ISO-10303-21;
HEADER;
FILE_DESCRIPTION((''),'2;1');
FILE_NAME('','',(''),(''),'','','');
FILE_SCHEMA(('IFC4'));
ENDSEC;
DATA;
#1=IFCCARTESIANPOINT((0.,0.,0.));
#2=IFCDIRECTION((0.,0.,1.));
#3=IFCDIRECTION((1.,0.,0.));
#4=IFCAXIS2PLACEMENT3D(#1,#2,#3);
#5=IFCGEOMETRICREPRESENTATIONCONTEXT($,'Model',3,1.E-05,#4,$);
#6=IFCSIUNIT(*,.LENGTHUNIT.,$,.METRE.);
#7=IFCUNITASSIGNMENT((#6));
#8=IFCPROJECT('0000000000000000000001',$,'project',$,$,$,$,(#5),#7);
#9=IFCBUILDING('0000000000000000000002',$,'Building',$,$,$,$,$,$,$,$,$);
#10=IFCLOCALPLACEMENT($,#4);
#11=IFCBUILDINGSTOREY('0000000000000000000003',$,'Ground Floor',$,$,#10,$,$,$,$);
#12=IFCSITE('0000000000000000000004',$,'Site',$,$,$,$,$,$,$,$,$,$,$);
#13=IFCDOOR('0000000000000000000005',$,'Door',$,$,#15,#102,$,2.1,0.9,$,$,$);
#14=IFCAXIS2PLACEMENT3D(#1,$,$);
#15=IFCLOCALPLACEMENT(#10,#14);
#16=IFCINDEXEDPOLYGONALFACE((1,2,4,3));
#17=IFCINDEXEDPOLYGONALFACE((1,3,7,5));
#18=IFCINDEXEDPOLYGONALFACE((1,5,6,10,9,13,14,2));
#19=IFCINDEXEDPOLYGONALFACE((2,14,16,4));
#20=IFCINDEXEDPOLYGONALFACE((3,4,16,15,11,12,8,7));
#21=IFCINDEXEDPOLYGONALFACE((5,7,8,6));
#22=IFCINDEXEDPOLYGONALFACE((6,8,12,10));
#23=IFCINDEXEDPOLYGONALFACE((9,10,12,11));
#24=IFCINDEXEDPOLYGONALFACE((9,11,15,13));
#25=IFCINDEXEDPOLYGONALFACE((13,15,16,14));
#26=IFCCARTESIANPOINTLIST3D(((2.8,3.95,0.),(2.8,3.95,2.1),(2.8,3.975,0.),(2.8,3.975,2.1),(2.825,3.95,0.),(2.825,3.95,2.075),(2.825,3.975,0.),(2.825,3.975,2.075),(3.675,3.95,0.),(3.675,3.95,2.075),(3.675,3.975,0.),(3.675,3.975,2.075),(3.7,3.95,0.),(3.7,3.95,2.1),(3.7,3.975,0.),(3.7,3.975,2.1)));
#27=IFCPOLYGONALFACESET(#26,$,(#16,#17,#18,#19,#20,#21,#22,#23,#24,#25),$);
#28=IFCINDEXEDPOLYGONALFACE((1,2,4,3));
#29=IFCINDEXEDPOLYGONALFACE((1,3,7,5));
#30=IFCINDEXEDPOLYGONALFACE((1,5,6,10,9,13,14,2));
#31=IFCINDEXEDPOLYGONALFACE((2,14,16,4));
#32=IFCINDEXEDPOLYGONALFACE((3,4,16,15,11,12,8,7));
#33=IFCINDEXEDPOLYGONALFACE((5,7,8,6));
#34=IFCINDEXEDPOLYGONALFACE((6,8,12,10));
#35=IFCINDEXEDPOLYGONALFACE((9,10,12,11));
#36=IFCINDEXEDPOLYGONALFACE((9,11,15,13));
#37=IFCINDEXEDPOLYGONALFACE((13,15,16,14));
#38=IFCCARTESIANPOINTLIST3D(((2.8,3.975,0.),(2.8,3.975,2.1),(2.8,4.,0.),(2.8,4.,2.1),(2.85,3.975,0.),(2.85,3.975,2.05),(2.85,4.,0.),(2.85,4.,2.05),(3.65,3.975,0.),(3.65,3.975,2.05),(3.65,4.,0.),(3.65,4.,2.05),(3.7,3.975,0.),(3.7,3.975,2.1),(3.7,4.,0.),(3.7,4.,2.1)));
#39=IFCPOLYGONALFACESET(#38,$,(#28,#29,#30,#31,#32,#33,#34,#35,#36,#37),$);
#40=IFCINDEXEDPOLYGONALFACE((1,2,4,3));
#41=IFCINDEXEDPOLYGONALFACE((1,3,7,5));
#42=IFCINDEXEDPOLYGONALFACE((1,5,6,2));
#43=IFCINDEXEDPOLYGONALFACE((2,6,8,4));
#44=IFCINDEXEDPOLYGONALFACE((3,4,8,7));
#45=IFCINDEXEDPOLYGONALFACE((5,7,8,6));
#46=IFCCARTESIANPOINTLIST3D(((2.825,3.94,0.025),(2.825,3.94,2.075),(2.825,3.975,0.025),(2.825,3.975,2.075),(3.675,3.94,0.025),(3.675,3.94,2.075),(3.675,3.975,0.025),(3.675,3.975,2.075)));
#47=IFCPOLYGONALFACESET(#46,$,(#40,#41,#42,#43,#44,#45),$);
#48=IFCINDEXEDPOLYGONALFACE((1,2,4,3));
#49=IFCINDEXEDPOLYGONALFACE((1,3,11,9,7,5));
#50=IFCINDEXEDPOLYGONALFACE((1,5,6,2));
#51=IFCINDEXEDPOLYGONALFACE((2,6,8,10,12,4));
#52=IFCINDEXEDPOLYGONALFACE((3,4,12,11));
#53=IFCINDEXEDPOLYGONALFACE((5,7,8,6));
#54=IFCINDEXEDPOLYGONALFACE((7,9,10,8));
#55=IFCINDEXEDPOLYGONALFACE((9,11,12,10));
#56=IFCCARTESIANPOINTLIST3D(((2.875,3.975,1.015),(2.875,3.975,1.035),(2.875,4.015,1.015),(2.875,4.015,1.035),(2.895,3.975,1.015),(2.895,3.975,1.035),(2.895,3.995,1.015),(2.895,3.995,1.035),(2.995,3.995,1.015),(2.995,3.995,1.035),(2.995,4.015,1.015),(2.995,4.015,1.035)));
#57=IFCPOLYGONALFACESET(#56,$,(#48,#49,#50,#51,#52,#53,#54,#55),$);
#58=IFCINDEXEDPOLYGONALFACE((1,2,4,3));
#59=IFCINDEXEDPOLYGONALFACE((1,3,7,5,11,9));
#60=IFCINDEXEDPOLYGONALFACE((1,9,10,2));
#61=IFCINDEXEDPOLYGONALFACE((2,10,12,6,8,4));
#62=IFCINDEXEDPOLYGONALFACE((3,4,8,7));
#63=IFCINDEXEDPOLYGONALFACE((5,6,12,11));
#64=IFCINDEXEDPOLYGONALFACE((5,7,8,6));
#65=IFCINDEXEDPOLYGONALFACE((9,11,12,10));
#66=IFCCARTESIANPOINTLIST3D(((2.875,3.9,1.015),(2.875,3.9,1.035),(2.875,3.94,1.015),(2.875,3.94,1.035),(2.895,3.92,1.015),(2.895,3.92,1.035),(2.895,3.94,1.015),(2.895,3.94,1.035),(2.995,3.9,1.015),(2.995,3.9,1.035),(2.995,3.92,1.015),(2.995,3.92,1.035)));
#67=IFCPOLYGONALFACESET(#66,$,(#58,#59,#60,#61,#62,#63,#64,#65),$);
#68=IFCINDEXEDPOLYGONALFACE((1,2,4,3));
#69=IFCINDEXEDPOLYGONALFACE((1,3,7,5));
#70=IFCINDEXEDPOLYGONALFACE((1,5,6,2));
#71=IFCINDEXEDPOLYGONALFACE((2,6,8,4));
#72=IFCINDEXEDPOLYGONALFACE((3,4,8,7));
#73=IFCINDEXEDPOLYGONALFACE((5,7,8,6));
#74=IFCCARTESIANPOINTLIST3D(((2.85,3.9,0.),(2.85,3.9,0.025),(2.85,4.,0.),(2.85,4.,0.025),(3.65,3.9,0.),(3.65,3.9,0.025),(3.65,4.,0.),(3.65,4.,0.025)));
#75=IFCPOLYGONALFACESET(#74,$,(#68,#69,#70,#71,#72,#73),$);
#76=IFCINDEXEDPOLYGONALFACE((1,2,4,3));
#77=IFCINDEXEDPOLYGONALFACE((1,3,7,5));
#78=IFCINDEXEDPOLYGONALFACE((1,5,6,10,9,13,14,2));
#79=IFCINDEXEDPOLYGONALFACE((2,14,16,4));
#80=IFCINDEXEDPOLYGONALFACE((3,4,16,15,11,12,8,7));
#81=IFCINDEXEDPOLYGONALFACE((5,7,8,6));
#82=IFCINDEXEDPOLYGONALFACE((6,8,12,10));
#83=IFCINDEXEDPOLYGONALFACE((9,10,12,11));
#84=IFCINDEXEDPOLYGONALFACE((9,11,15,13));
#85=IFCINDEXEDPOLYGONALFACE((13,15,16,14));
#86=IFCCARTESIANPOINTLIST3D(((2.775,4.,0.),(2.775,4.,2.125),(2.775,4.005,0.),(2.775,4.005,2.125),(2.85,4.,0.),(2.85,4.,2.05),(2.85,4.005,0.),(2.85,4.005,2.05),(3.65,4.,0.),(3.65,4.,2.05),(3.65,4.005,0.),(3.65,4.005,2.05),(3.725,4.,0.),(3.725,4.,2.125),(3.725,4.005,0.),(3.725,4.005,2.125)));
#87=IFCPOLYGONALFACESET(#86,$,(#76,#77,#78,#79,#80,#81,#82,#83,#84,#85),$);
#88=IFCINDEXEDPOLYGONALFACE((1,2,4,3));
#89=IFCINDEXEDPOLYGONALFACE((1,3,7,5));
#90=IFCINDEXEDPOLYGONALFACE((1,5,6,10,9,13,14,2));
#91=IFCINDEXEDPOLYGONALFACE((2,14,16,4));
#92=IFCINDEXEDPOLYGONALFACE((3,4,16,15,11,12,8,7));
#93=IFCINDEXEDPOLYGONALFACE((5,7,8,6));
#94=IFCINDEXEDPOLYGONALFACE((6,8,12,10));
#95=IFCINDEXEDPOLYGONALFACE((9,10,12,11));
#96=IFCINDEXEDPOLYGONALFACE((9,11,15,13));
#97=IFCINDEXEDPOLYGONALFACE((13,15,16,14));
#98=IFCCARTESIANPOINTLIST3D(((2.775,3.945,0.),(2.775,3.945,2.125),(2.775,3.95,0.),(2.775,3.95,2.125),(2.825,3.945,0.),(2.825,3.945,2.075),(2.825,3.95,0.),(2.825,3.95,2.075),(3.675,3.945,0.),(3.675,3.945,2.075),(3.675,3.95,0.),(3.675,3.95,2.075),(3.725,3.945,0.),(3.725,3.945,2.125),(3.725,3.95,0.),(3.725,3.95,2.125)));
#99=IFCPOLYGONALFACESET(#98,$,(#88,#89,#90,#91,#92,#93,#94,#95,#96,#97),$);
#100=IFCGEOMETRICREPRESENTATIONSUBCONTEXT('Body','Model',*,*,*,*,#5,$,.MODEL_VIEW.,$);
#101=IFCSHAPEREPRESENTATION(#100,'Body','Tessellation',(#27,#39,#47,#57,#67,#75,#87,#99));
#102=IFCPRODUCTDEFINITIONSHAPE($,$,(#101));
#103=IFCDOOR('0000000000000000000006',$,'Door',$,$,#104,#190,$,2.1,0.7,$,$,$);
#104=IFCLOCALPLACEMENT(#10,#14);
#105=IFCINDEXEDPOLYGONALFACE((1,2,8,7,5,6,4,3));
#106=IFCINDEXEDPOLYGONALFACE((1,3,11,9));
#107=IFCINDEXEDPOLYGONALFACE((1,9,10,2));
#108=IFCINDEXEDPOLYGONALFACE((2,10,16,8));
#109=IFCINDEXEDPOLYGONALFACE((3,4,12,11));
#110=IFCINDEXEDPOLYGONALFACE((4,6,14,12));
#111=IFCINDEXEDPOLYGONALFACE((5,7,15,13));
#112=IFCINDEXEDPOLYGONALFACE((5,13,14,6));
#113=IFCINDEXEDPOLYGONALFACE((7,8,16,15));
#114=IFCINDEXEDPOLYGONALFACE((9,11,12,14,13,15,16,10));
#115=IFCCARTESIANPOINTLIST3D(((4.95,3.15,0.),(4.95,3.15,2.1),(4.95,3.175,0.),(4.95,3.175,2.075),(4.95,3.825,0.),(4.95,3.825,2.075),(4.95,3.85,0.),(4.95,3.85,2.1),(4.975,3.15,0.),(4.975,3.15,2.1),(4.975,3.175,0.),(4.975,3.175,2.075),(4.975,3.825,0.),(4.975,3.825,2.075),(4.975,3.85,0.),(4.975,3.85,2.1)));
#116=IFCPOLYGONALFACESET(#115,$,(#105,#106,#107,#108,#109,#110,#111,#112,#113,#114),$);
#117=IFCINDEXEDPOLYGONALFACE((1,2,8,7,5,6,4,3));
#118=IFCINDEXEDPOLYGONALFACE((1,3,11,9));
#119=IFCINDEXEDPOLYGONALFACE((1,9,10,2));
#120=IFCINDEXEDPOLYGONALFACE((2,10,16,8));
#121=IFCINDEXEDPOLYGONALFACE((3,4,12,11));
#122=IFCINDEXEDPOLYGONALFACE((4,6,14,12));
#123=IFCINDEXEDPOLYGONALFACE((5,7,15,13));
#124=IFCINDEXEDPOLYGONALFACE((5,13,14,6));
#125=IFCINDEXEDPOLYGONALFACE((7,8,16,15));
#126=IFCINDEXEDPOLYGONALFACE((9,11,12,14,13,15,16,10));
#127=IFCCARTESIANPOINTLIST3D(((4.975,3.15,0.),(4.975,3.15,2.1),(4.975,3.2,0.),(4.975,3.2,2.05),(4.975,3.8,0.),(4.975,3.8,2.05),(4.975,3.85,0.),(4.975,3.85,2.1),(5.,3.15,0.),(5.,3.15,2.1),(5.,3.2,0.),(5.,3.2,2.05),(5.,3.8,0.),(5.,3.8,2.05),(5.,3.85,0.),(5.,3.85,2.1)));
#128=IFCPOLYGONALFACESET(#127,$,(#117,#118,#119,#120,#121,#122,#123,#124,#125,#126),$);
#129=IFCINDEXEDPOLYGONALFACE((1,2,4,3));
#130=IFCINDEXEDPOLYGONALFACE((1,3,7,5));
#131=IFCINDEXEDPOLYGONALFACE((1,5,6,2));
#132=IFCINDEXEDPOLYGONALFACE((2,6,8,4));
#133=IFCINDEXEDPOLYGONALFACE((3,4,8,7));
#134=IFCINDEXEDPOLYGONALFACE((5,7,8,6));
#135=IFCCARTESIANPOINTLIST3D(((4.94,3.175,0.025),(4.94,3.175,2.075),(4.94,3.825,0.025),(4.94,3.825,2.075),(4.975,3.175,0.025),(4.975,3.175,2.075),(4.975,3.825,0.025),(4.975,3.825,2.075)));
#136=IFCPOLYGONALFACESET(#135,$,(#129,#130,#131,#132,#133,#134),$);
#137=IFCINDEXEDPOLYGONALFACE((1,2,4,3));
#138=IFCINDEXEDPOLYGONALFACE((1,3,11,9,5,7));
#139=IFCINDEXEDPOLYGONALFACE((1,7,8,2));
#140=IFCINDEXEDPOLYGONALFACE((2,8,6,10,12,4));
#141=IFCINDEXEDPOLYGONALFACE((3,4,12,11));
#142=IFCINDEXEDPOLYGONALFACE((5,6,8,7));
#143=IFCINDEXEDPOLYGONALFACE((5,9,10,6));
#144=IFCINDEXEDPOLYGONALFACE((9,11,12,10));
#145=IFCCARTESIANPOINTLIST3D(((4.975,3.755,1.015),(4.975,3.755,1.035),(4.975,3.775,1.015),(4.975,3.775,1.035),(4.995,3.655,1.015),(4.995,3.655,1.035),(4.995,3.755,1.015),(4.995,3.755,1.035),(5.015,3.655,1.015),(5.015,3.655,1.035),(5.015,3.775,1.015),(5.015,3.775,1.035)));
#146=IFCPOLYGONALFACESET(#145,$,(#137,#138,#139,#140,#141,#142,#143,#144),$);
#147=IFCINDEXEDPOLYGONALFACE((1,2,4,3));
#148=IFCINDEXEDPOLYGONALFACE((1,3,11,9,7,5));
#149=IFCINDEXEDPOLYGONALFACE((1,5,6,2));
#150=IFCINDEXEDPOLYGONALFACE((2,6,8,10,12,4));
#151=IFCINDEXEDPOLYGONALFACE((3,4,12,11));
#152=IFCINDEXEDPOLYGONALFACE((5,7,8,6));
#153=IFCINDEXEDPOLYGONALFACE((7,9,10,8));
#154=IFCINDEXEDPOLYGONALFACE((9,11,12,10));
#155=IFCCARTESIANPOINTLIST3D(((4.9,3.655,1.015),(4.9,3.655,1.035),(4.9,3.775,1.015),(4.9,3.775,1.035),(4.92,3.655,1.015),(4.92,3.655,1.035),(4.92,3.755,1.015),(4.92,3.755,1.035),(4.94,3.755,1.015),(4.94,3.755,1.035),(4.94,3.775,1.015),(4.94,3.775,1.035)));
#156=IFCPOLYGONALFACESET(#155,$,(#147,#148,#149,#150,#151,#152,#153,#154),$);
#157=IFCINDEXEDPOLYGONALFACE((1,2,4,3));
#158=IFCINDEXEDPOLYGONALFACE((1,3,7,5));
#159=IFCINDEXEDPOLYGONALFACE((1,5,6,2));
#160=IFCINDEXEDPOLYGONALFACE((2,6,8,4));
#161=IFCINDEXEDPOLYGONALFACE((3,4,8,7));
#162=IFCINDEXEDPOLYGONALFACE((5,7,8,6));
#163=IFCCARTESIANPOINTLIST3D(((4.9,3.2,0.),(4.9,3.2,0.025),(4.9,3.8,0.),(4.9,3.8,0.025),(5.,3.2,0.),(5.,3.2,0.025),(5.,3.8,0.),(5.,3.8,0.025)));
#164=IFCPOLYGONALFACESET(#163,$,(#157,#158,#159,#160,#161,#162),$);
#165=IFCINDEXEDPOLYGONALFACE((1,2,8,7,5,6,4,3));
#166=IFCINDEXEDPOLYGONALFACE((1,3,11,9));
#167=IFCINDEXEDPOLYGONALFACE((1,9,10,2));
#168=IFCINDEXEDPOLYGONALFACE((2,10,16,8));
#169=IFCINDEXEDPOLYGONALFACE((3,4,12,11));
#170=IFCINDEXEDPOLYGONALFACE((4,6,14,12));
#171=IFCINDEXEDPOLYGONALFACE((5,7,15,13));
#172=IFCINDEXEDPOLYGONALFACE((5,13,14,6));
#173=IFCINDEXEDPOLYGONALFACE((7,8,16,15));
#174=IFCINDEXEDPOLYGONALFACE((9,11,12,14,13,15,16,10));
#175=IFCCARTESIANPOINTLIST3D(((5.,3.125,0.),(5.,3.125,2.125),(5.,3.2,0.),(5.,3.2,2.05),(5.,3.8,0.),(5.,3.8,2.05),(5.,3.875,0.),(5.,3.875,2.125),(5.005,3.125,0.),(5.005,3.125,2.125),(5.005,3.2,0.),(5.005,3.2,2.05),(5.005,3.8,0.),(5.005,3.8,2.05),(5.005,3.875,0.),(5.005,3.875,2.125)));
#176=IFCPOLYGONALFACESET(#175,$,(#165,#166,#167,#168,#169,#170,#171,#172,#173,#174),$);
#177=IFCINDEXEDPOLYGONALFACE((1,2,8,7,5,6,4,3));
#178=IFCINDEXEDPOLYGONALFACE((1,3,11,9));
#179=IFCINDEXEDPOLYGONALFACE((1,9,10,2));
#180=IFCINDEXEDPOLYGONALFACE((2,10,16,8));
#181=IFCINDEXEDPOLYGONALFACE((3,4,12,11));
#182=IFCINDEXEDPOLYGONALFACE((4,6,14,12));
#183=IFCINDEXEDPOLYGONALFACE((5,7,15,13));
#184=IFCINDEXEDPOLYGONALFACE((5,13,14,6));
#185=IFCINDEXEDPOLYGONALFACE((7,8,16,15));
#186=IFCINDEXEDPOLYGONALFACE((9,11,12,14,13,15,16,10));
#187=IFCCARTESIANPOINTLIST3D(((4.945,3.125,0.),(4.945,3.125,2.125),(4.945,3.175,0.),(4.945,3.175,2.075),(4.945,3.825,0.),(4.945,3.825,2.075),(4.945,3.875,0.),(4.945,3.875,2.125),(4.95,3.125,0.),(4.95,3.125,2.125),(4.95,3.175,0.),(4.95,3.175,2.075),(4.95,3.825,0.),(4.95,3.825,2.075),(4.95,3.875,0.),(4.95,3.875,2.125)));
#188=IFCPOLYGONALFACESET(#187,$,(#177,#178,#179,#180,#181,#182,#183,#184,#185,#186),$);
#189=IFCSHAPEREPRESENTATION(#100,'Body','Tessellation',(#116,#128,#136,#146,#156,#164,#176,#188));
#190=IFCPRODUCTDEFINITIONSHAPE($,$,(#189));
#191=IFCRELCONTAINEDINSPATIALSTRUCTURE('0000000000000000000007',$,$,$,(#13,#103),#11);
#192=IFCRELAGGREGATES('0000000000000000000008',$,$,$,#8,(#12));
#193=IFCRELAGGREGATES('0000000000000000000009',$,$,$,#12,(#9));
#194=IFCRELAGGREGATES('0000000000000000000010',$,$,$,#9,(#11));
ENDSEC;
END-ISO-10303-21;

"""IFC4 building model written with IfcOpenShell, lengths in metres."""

from ifc_helpers import new_model, si_unit, frame, origin_with_axes, place, context, subcontext, project, spatial, line, indexed_curve, outline, extrude, element, save


model = new_model("IFC4")

# Units and contexts
model_context = context("Model", 3, precision=1e-05, world=origin_with_axes())
body_context = subcontext(model_context, "Body", "Model", "MODEL_VIEW")
ifc_project = project(units=[si_unit("LENGTHUNIT", "METRE")], contexts=[model_context])

# Site, building, storey
site = spatial("IfcSite", under=ifc_project, Name="Site")
building = spatial("IfcBuilding", under=site, Name="Building")
storey_placement = place(None, origin_with_axes())
storey = spatial("IfcBuildingStorey", under=building, at=storey_placement, Name="Ground Floor")

# Doors
door_1_placement = place(storey_placement, frame((3.7, 4.0, 0.0), z_axis=(0.0, 0.0, 1.0), x_axis=(-1.0, 0.0, 0.0)))
element("IfcDoor", 1, at=door_1_placement, inside=storey, Name="Door", OverallHeight=2.1, OverallWidth=0.9, context=body_context, shape_type="SweptSolid", body=[
    extrude(outline(indexed_curve([(0.0, 0.0), (0.0, 2.1), (0.9, 2.1), (0.9, 0.0), (0.875, 0.0), (0.875, 2.075), (0.025, 2.075), (0.025, 0.0)], segments=[line(1, 2, 3, 4, 5, 6, 7, 8, 1)])), frame((0.0, 0.025, 0.0), z_axis=(0.0, -1.0, 0.0), x_axis=(1.0, 0.0, 0.0)), (0.0, 0.0, -1.0), 0.025),
    extrude(outline(indexed_curve([(0.0, 0.0), (0.0, 2.1), (0.9, 2.1), (0.9, 0.0), (0.85, 0.0), (0.85, 2.05), (0.05, 2.05), (0.05, 0.0)], segments=[line(1, 2, 3, 4, 5, 6, 7, 8, 1)])), frame((0.0, 0.0, 0.0), z_axis=(0.0, -1.0, 0.0), x_axis=(1.0, 0.0, 0.0)), (0.0, 0.0, -1.0), 0.025),
    extrude(outline(indexed_curve([(0.0, 0.0), (0.85, 0.0), (0.85, 0.035), (0.0, 0.035)], segments=[line(1, 2, 3, 4, 1)])), frame((0.025, 0.025, 0.025), z_axis=(0.0, 0.0, 1.0), x_axis=(1.0, 0.0, 0.0)), (0.0, 0.0, 1.0), 2.05),
    extrude(outline(indexed_curve([(0.0, 0.0), (0.0, -0.04), (-0.12, -0.04), (-0.12, -0.02), (-0.02, -0.02), (-0.02, 0.0)], segments=[line(1, 2, 3, 4, 5, 6, 1)])), frame((0.825, 0.025, 1.015), z_axis=(0.0, 0.0, 1.0), x_axis=(1.0, 0.0, 0.0)), (0.0, 0.0, 1.0), 0.02),
    extrude(outline(indexed_curve([(0.0, 0.0), (0.0, 0.04), (-0.12, 0.04), (-0.12, 0.02), (-0.02, 0.02), (-0.02, 0.0)], segments=[line(1, 2, 3, 4, 5, 6, 1)])), frame((0.825, 0.06, 1.015), z_axis=(0.0, 0.0, 1.0), x_axis=(1.0, 0.0, 0.0)), (0.0, 0.0, 1.0), 0.02),
    extrude(outline(indexed_curve([(0.0, 0.0), (0.8, 0.0), (0.8, 0.1), (0.0, 0.1)], segments=[line(1, 2, 3, 4, 1)])), frame((0.05, 0.0, 0.0), z_axis=(0.0, 0.0, 1.0), x_axis=(1.0, 0.0, 0.0)), (0.0, 0.0, 1.0), 0.025),
    extrude(outline(indexed_curve([(0.0, 0.0), (0.0, 2.125), (0.95, 2.125), (0.95, 0.0), (0.875, 0.0), (0.875, 2.05), (0.075, 2.05), (0.075, 0.0)], segments=[line(1, 2, 3, 4, 5, 6, 7, 8, 1)])), frame((-0.025, -0.005, 0.0), z_axis=(0.0, -1.0, 0.0), x_axis=(1.0, 0.0, 0.0)), (0.0, 0.0, -1.0), 0.005),
    extrude(outline(indexed_curve([(0.0, 0.0), (0.0, 2.125), (0.95, 2.125), (0.95, 0.0), (0.9, 0.0), (0.9, 2.075), (0.05, 2.075), (0.05, 0.0)], segments=[line(1, 2, 3, 4, 5, 6, 7, 8, 1)])), frame((-0.025, 0.05, 0.0), z_axis=(0.0, -1.0, 0.0), x_axis=(1.0, 0.0, 0.0)), (0.0, 0.0, -1.0), 0.005),
])
door_2_placement = place(storey_placement, frame((5.0, 3.15, 0.0), z_axis=(0.0, 0.0, 1.0), x_axis=(0.0, 1.0, 0.0)))
element("IfcDoor", 2, at=door_2_placement, inside=storey, Name="Door", OverallHeight=2.1, OverallWidth=0.7, context=body_context, shape_type="SweptSolid", body=[
    extrude(outline(indexed_curve([(0.0, 0.0), (0.0, 2.1), (0.7, 2.1), (0.7, 0.0), (0.675, 0.0), (0.675, 2.075), (0.025, 2.075), (0.025, 0.0)], segments=[line(1, 2, 3, 4, 5, 6, 7, 8, 1)])), frame((0.0, 0.025, 0.0), z_axis=(0.0, -1.0, 0.0), x_axis=(1.0, 0.0, 0.0)), (0.0, 0.0, -1.0), 0.025),
    extrude(outline(indexed_curve([(0.0, 0.0), (0.0, 2.1), (0.7, 2.1), (0.7, 0.0), (0.65, 0.0), (0.65, 2.05), (0.05, 2.05), (0.05, 0.0)], segments=[line(1, 2, 3, 4, 5, 6, 7, 8, 1)])), frame((0.0, 0.0, 0.0), z_axis=(0.0, -1.0, 0.0), x_axis=(1.0, 0.0, 0.0)), (0.0, 0.0, -1.0), 0.025),
    extrude(outline(indexed_curve([(0.0, 0.0), (0.65, 0.0), (0.65, 0.035), (0.0, 0.035)], segments=[line(1, 2, 3, 4, 1)])), frame((0.025, 0.025, 0.025), z_axis=(0.0, 0.0, 1.0), x_axis=(1.0, 0.0, 0.0)), (0.0, 0.0, 1.0), 2.05),
    extrude(outline(indexed_curve([(0.0, 0.0), (0.0, -0.04), (-0.12, -0.04), (-0.12, -0.02), (-0.02, -0.02), (-0.02, 0.0)], segments=[line(1, 2, 3, 4, 5, 6, 1)])), frame((0.625, 0.025, 1.015), z_axis=(0.0, 0.0, 1.0), x_axis=(1.0, 0.0, 0.0)), (0.0, 0.0, 1.0), 0.02),
    extrude(outline(indexed_curve([(0.0, 0.0), (0.0, 0.04), (-0.12, 0.04), (-0.12, 0.02), (-0.02, 0.02), (-0.02, 0.0)], segments=[line(1, 2, 3, 4, 5, 6, 1)])), frame((0.625, 0.06, 1.015), z_axis=(0.0, 0.0, 1.0), x_axis=(1.0, 0.0, 0.0)), (0.0, 0.0, 1.0), 0.02),
    extrude(outline(indexed_curve([(0.0, 0.0), (0.6, 0.0), (0.6, 0.1), (0.0, 0.1)], segments=[line(1, 2, 3, 4, 1)])), frame((0.05, 0.0, 0.0), z_axis=(0.0, 0.0, 1.0), x_axis=(1.0, 0.0, 0.0)), (0.0, 0.0, 1.0), 0.025),
    extrude(outline(indexed_curve([(0.0, 0.0), (0.0, 2.125), (0.75, 2.125), (0.75, 0.0), (0.675, 0.0), (0.675, 2.05), (0.075, 2.05), (0.075, 0.0)], segments=[line(1, 2, 3, 4, 5, 6, 7, 8, 1)])), frame((-0.025, -0.005, 0.0), z_axis=(0.0, -1.0, 0.0), x_axis=(1.0, 0.0, 0.0)), (0.0, 0.0, -1.0), 0.005),
    extrude(outline(indexed_curve([(0.0, 0.0), (0.0, 2.125), (0.75, 2.125), (0.75, 0.0), (0.7, 0.0), (0.7, 2.075), (0.05, 2.075), (0.05, 0.0)], segments=[line(1, 2, 3, 4, 5, 6, 7, 8, 1)])), frame((-0.025, 0.05, 0.0), z_axis=(0.0, -1.0, 0.0), x_axis=(1.0, 0.0, 0.0)), (0.0, 0.0, -1.0), 0.005),
])

save(model, "model.ifc")
